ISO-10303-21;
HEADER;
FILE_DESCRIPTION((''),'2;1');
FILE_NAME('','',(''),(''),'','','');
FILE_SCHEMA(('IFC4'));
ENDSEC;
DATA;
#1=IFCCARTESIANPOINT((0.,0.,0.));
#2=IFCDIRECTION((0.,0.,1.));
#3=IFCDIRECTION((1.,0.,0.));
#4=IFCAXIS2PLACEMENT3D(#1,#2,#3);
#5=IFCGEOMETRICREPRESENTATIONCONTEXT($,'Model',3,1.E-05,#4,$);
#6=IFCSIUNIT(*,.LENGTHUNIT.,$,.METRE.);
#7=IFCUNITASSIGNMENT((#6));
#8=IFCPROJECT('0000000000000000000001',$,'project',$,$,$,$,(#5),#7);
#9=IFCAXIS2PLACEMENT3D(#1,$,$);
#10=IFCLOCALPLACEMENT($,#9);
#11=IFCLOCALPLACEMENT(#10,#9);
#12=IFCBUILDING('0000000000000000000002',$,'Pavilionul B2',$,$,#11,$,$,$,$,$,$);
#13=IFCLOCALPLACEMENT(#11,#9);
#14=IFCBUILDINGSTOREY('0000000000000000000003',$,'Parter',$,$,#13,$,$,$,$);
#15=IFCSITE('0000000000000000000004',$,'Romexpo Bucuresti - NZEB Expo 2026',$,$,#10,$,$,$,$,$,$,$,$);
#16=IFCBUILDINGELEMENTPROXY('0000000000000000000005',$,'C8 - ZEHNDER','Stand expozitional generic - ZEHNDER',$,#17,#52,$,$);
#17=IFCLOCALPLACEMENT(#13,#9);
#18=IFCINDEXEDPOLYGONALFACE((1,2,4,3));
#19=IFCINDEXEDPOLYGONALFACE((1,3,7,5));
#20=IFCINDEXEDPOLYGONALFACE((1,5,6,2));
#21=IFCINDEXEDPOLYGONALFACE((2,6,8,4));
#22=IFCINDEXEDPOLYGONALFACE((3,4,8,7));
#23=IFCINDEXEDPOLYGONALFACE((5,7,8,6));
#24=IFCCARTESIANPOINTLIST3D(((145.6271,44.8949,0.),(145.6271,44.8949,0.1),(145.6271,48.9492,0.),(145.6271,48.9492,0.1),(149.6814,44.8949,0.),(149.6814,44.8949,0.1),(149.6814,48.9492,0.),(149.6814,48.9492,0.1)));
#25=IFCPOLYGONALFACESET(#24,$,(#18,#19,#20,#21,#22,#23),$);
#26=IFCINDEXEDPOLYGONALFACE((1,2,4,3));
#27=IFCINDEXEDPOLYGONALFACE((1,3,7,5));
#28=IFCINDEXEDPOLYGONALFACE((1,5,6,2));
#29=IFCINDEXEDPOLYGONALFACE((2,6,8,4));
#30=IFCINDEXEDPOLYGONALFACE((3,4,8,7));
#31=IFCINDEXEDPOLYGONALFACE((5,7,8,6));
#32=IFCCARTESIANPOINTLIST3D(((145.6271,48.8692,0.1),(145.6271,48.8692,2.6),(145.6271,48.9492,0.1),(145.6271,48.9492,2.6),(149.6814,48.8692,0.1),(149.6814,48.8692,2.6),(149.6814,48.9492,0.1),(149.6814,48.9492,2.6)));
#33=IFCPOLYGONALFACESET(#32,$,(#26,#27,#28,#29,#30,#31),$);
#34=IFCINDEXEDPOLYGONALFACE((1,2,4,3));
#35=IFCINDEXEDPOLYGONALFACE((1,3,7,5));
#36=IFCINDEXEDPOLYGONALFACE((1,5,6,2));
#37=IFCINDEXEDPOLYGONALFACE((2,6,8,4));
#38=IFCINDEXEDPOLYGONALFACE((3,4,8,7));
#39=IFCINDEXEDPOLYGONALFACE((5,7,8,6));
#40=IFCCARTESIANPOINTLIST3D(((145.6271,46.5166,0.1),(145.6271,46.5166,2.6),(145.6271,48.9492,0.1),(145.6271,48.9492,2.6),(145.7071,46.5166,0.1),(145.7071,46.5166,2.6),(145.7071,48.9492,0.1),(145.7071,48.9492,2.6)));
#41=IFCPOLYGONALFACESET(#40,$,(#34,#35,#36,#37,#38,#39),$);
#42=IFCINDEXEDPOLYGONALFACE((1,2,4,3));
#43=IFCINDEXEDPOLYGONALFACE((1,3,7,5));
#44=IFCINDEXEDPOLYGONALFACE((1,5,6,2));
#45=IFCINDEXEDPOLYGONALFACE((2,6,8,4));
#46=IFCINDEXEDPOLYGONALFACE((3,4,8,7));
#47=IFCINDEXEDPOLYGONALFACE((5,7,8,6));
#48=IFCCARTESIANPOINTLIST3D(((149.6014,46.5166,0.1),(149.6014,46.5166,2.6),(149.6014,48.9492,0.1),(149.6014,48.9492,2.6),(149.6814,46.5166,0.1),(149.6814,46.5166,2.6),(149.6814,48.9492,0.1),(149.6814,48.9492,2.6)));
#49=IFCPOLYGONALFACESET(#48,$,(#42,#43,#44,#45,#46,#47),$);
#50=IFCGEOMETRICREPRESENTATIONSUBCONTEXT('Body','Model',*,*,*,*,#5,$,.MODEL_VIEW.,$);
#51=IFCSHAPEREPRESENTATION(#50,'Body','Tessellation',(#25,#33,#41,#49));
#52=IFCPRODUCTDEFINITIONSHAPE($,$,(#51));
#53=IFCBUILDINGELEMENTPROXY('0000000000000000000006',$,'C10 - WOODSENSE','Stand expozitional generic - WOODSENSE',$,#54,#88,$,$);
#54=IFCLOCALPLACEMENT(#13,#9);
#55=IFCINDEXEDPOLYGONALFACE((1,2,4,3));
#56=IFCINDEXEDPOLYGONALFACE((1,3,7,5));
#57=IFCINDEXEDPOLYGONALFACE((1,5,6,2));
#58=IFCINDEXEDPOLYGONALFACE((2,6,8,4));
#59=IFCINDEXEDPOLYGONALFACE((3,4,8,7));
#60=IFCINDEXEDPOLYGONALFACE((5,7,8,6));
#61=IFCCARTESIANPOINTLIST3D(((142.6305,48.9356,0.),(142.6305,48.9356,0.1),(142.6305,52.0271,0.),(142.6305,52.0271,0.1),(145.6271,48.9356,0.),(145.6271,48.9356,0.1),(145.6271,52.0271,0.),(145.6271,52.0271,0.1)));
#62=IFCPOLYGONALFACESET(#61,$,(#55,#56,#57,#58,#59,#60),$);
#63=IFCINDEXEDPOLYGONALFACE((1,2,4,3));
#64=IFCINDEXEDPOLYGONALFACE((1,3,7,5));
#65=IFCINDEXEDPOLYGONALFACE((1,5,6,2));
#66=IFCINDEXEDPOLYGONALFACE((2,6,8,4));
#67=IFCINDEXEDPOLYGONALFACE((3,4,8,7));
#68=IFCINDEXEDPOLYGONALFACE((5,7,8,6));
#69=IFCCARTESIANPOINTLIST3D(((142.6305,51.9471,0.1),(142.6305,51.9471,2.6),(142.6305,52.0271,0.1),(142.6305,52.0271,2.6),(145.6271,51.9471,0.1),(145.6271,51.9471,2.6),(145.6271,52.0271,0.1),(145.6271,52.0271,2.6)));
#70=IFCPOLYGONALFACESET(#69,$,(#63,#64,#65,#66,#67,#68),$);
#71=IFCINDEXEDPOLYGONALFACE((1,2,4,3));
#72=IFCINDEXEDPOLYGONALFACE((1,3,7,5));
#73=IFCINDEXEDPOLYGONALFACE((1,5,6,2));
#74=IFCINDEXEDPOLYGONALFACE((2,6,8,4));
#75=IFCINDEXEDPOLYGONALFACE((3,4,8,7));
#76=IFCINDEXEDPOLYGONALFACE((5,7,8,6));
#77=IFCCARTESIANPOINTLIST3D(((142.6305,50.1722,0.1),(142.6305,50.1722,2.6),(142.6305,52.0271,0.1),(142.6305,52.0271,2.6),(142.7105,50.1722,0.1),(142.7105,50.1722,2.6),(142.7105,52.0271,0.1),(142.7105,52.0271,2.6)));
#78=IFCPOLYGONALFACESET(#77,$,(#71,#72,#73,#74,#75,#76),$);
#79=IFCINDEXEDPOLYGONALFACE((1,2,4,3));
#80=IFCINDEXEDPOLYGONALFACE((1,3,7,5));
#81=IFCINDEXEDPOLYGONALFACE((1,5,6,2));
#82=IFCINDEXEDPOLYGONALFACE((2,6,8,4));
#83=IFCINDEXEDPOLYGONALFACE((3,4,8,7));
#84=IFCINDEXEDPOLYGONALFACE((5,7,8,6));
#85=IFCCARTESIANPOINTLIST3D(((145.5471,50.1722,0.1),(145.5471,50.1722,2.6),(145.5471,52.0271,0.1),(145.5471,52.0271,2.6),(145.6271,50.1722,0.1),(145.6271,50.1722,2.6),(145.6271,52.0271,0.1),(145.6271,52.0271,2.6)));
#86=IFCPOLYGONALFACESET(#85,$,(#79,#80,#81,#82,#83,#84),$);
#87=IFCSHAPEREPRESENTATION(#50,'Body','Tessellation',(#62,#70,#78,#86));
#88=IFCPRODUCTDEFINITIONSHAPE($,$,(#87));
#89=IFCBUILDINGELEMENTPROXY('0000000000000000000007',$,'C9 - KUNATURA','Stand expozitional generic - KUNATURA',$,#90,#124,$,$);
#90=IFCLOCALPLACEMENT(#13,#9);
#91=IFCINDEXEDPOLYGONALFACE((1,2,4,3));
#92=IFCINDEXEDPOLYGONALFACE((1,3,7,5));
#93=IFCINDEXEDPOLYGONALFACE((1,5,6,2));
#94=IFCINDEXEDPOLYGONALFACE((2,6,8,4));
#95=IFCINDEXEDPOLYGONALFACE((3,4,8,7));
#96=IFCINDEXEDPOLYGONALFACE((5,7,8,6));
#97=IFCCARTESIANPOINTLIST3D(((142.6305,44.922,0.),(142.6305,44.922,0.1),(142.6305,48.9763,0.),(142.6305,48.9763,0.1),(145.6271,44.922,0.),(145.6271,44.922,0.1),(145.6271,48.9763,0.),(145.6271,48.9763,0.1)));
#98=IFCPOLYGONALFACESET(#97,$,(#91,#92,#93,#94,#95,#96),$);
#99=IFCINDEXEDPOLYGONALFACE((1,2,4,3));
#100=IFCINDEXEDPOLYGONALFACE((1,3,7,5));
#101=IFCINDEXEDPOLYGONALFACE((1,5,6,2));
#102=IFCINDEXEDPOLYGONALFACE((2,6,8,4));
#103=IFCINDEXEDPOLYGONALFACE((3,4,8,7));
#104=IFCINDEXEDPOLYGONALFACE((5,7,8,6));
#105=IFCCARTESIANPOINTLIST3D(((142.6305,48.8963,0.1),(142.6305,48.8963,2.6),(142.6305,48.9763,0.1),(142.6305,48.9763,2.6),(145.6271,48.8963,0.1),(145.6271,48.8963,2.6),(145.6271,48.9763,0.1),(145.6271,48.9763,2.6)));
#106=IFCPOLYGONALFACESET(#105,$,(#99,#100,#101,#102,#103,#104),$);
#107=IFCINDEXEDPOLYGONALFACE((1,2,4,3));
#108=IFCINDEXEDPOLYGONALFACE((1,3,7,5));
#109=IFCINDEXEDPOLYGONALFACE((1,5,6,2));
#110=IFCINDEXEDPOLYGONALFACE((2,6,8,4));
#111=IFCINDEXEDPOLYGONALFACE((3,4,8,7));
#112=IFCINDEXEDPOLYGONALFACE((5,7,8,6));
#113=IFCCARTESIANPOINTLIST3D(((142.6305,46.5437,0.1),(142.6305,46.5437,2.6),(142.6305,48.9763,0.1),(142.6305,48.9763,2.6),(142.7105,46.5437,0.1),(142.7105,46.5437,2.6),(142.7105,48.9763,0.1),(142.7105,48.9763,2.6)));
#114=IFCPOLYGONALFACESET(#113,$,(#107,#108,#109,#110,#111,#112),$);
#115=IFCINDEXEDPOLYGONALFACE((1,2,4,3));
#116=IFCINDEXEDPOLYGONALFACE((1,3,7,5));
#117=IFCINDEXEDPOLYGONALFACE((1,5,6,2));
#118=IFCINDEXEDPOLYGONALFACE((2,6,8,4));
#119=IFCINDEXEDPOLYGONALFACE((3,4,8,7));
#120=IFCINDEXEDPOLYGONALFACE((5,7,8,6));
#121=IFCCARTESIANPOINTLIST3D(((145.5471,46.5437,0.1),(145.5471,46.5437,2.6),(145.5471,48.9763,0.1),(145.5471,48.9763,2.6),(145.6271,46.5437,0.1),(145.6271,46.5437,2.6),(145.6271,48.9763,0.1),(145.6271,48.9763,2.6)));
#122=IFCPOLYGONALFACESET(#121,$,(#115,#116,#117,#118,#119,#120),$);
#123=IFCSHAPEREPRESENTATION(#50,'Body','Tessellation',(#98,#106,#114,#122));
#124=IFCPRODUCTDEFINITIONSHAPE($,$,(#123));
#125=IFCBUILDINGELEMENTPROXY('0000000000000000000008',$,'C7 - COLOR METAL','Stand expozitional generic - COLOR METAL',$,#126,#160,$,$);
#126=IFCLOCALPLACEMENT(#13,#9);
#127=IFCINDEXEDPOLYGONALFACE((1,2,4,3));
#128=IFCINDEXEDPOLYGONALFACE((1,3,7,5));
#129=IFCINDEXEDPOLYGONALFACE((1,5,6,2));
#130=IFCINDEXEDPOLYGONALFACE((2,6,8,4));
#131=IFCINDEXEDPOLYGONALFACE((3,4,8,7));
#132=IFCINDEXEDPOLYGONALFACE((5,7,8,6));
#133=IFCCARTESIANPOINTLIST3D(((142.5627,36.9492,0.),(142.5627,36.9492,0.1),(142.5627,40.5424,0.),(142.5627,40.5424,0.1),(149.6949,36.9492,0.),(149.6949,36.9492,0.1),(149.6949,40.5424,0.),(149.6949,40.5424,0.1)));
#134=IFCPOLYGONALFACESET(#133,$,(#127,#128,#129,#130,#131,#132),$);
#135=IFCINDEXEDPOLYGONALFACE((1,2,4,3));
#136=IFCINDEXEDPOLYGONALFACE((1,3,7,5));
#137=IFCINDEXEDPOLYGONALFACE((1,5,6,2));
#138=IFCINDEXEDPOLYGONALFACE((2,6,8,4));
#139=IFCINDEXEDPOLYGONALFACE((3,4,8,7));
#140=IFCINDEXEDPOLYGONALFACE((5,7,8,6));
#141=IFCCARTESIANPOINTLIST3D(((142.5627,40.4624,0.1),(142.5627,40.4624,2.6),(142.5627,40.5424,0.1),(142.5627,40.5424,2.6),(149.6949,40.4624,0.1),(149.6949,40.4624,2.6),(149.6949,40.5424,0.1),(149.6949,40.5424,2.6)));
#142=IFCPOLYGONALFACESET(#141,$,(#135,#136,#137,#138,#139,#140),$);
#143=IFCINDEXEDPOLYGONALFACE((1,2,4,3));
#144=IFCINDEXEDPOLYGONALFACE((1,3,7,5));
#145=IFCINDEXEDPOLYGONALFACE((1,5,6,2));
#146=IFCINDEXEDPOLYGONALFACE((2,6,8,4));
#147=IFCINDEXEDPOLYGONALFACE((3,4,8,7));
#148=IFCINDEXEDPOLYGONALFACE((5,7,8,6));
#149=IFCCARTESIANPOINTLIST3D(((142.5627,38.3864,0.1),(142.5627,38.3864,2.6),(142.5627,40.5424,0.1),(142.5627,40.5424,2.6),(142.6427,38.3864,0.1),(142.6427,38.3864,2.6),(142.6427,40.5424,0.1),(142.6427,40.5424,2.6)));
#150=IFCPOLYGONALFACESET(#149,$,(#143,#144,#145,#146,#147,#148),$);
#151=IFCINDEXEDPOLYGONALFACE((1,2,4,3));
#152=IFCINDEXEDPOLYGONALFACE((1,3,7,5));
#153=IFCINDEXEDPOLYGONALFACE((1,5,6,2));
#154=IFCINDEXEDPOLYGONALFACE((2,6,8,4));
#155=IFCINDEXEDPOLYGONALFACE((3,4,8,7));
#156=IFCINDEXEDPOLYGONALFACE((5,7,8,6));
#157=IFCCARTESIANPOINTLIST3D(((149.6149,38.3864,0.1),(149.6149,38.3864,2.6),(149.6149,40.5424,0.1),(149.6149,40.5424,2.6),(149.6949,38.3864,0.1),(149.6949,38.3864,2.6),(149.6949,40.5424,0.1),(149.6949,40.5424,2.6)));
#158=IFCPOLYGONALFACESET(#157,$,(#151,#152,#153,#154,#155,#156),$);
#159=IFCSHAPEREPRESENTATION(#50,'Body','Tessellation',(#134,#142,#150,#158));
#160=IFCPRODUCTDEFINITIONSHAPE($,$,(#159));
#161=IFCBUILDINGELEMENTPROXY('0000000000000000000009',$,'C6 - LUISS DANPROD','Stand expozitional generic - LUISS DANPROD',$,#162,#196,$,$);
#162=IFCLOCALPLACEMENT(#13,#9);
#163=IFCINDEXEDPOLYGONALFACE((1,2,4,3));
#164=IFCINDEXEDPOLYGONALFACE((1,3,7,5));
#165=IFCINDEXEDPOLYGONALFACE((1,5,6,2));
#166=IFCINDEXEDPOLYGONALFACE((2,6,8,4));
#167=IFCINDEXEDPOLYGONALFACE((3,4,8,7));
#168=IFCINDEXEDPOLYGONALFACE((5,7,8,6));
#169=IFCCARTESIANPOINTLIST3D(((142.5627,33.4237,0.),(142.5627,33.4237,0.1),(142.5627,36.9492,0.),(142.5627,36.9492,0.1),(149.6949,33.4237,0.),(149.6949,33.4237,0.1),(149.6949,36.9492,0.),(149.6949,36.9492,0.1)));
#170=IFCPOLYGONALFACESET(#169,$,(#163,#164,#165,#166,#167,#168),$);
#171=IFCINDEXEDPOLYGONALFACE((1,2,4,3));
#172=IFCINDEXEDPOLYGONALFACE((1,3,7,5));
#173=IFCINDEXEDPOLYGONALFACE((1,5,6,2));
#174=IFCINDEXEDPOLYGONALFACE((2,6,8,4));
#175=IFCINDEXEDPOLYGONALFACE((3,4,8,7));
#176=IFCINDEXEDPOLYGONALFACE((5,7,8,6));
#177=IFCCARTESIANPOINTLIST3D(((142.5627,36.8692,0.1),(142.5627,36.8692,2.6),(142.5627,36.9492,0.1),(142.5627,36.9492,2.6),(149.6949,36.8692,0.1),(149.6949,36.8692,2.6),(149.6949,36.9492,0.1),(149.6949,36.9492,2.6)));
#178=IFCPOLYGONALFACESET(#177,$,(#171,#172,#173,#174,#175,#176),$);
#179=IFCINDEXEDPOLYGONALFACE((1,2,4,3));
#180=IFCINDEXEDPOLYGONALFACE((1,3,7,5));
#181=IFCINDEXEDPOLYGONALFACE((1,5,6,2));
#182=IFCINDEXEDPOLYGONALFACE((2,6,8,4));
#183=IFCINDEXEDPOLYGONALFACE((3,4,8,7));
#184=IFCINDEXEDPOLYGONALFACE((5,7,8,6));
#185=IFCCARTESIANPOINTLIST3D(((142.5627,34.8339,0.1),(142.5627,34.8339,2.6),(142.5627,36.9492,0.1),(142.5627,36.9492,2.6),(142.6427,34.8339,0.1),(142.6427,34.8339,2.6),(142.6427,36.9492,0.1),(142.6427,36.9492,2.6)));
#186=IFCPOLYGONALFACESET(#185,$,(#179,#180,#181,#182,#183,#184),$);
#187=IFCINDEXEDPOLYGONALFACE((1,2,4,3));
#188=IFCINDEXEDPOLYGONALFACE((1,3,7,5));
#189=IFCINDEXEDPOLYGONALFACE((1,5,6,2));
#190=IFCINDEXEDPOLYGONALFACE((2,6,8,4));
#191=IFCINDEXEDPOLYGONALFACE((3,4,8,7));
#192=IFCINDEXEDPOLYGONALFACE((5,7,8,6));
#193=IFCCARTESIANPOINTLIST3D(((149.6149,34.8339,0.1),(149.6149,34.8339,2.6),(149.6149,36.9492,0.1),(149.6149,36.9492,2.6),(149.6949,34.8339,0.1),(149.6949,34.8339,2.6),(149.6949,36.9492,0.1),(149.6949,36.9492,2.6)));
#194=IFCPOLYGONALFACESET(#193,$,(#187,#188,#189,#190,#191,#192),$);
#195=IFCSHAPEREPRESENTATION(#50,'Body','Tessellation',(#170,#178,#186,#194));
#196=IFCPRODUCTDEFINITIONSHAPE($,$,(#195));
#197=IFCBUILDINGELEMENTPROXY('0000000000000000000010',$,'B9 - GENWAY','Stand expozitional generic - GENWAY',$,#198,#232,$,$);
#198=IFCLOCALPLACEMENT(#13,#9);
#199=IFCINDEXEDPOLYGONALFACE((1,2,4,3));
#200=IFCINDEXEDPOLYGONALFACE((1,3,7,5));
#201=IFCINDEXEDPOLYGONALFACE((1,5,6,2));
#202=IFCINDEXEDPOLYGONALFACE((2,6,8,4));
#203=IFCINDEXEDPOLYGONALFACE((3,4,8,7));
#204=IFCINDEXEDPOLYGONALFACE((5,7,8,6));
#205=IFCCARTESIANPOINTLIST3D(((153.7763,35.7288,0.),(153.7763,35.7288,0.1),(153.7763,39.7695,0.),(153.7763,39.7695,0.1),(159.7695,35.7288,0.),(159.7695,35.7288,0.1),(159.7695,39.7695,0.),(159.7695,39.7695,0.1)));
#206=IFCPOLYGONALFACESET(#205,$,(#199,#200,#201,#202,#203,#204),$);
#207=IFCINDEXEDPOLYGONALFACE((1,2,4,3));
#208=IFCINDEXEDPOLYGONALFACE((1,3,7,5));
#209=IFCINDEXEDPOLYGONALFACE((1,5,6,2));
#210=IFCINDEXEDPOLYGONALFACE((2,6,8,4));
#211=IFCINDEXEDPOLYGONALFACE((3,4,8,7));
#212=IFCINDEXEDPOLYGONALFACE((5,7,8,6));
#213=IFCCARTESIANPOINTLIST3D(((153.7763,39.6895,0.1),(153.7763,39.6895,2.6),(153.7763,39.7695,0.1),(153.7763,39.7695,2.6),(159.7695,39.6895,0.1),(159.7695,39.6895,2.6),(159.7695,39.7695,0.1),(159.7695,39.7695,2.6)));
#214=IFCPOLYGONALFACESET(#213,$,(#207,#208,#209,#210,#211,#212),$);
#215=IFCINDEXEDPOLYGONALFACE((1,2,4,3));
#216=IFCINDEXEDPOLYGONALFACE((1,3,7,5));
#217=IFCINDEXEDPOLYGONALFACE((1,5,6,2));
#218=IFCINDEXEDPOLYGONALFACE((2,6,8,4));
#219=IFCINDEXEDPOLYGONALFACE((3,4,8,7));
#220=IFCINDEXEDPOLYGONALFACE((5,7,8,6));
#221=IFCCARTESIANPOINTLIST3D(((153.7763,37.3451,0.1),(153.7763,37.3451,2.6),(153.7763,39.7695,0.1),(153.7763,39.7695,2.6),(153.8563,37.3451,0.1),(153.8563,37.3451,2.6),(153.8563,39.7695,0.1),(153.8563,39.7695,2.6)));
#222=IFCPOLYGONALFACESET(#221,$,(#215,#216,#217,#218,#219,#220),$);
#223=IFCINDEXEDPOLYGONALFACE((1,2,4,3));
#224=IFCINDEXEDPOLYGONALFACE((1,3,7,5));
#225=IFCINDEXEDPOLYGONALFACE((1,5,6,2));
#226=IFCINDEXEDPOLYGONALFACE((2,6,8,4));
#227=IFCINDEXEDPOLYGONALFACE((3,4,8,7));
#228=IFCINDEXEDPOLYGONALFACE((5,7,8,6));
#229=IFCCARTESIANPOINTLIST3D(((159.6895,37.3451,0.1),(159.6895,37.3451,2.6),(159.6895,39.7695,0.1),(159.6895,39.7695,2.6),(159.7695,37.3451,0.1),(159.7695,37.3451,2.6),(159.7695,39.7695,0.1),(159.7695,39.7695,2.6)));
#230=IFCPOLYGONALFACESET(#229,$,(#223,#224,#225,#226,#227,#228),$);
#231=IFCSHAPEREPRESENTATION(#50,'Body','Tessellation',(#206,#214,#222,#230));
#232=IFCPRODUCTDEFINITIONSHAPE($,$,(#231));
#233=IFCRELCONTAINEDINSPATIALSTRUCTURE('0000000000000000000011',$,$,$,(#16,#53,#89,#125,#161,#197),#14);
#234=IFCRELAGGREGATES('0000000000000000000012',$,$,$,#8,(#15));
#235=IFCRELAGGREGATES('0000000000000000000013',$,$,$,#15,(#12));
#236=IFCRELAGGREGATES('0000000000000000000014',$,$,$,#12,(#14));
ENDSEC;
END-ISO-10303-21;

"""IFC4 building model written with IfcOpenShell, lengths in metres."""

from ifc_helpers import new_model, si_unit, frame, frame_2d, origin, origin_with_axes, place, context, subcontext, project, spatial, rectangle, extrude, element, save


model = new_model("IFC4")

# Units and contexts
model_context = context("Model", 3, precision=1e-05, world=origin_with_axes())
body_context = subcontext(model_context, "Body", "Model", "MODEL_VIEW")
ifc_project = project(units=[si_unit("LENGTHUNIT", "METRE")], contexts=[model_context])

# Site, building, storey
site_placement = place(None, origin())
site = spatial("IfcSite", under=ifc_project, at=site_placement, Name="Romexpo Bucuresti - NZEB Expo 2026")
building_placement = place(site_placement, origin())
building = spatial("IfcBuilding", under=site, at=building_placement, Name="Pavilionul B2")
storey_placement = place(building_placement, origin())
storey = spatial("IfcBuildingStorey", under=building, at=storey_placement, Name="Parter")

# Building element proxies
proxy_1_placement = place(storey_placement, frame((145.6271, 44.8949, 0.0), z_axis=(0.0, 0.0, 1.0), x_axis=(1.0, 0.0, 0.0)))
element("IfcBuildingElementProxy", 1, at=proxy_1_placement, inside=storey, Name="C8 - ZEHNDER", Description="Stand expozitional generic - ZEHNDER", context=body_context, shape_type="SweptSolid", body=[
    extrude(rectangle(XDim=4.0542, YDim=4.0542, at=frame_2d((2.0271, 2.0271))), origin(), (0.0, 0.0, 1.0), 0.1),
    extrude(rectangle(XDim=4.0542, YDim=0.08, at=frame_2d((2.0271, 4.0142))), frame((0.0, 0.0, 0.1)), (0.0, 0.0, 1.0), 2.5),
    extrude(rectangle(XDim=0.08, YDim=2.4325, at=frame_2d((0.04, 2.838))), frame((0.0, 0.0, 0.1)), (0.0, 0.0, 1.0), 2.5),
    extrude(rectangle(XDim=0.08, YDim=2.4325, at=frame_2d((4.0142, 2.838))), frame((0.0, 0.0, 0.1)), (0.0, 0.0, 1.0), 2.5),
])
proxy_2_placement = place(storey_placement, frame((142.6305, 48.9356, 0.0), z_axis=(0.0, 0.0, 1.0), x_axis=(1.0, 0.0, 0.0)))
element("IfcBuildingElementProxy", 2, at=proxy_2_placement, inside=storey, Name="C10 - WOODSENSE", Description="Stand expozitional generic - WOODSENSE", context=body_context, shape_type="SweptSolid", body=[
    extrude(rectangle(XDim=2.9966, YDim=3.0915, at=frame_2d((1.4983, 1.5458))), origin(), (0.0, 0.0, 1.0), 0.1),
    extrude(rectangle(XDim=2.9966, YDim=0.08, at=frame_2d((1.4983, 3.0515))), frame((0.0, 0.0, 0.1)), (0.0, 0.0, 1.0), 2.5),
    extrude(rectangle(XDim=0.08, YDim=1.8549, at=frame_2d((0.04, 2.1641))), frame((0.0, 0.0, 0.1)), (0.0, 0.0, 1.0), 2.5),
    extrude(rectangle(XDim=0.08, YDim=1.8549, at=frame_2d((2.9566, 2.1641))), frame((0.0, 0.0, 0.1)), (0.0, 0.0, 1.0), 2.5),
])
proxy_3_placement = place(storey_placement, frame((142.6305, 44.922, 0.0), z_axis=(0.0, 0.0, 1.0), x_axis=(1.0, 0.0, 0.0)))
element("IfcBuildingElementProxy", 3, at=proxy_3_placement, inside=storey, Name="C9 - KUNATURA", Description="Stand expozitional generic - KUNATURA", context=body_context, shape_type="SweptSolid", body=[
    extrude(rectangle(XDim=2.9966, YDim=4.0542, at=frame_2d((1.4983, 2.0271))), origin(), (0.0, 0.0, 1.0), 0.1),
    extrude(rectangle(XDim=2.9966, YDim=0.08, at=frame_2d((1.4983, 4.0142))), frame((0.0, 0.0, 0.1)), (0.0, 0.0, 1.0), 2.5),
    extrude(rectangle(XDim=0.08, YDim=2.4325, at=frame_2d((0.04, 2.838))), frame((0.0, 0.0, 0.1)), (0.0, 0.0, 1.0), 2.5),
    extrude(rectangle(XDim=0.08, YDim=2.4325, at=frame_2d((2.9566, 2.838))), frame((0.0, 0.0, 0.1)), (0.0, 0.0, 1.0), 2.5),
])
proxy_4_placement = place(storey_placement, frame((142.5627, 36.9492, 0.0), z_axis=(0.0, 0.0, 1.0), x_axis=(1.0, 0.0, 0.0)))
element("IfcBuildingElementProxy", 4, at=proxy_4_placement, inside=storey, Name="C7 - COLOR METAL", Description="Stand expozitional generic - COLOR METAL", context=body_context, shape_type="SweptSolid", body=[
    extrude(rectangle(XDim=7.1322, YDim=3.5932, at=frame_2d((3.5661, 1.7966))), origin(), (0.0, 0.0, 1.0), 0.1),
    extrude(rectangle(XDim=7.1322, YDim=0.08, at=frame_2d((3.5661, 3.5532))), frame((0.0, 0.0, 0.1)), (0.0, 0.0, 1.0), 2.5),
    extrude(rectangle(XDim=0.08, YDim=2.1559, at=frame_2d((0.04, 2.5153))), frame((0.0, 0.0, 0.1)), (0.0, 0.0, 1.0), 2.5),
    extrude(rectangle(XDim=0.08, YDim=2.1559, at=frame_2d((7.0922, 2.5153))), frame((0.0, 0.0, 0.1)), (0.0, 0.0, 1.0), 2.5),
])
proxy_5_placement = place(storey_placement, frame((142.5627, 33.4237, 0.0), z_axis=(0.0, 0.0, 1.0), x_axis=(1.0, 0.0, 0.0)))
element("IfcBuildingElementProxy", 5, at=proxy_5_placement, inside=storey, Name="C6 - LUISS DANPROD", Description="Stand expozitional generic - LUISS DANPROD", context=body_context, shape_type="SweptSolid", body=[
    extrude(rectangle(XDim=7.1322, YDim=3.5254, at=frame_2d((3.5661, 1.7627))), origin(), (0.0, 0.0, 1.0), 0.1),
    extrude(rectangle(XDim=7.1322, YDim=0.08, at=frame_2d((3.5661, 3.4854))), frame((0.0, 0.0, 0.1)), (0.0, 0.0, 1.0), 2.5),
    extrude(rectangle(XDim=0.08, YDim=2.1153, at=frame_2d((0.04, 2.4678))), frame((0.0, 0.0, 0.1)), (0.0, 0.0, 1.0), 2.5),
    extrude(rectangle(XDim=0.08, YDim=2.1153, at=frame_2d((7.0922, 2.4678))), frame((0.0, 0.0, 0.1)), (0.0, 0.0, 1.0), 2.5),
])
proxy_6_placement = place(storey_placement, frame((153.7763, 35.7288, 0.0), z_axis=(0.0, 0.0, 1.0), x_axis=(1.0, 0.0, 0.0)))
element("IfcBuildingElementProxy", 6, at=proxy_6_placement, inside=storey, Name="B9 - GENWAY", Description="Stand expozitional generic - GENWAY", context=body_context, shape_type="SweptSolid", body=[
    extrude(rectangle(XDim=5.9932, YDim=4.0407, at=frame_2d((2.9966, 2.0203))), origin(), (0.0, 0.0, 1.0), 0.1),
    extrude(rectangle(XDim=5.9932, YDim=0.08, at=frame_2d((2.9966, 4.0007))), frame((0.0, 0.0, 0.1)), (0.0, 0.0, 1.0), 2.5),
    extrude(rectangle(XDim=0.08, YDim=2.4244, at=frame_2d((0.04, 2.8285))), frame((0.0, 0.0, 0.1)), (0.0, 0.0, 1.0), 2.5),
    extrude(rectangle(XDim=0.08, YDim=2.4244, at=frame_2d((5.9532, 2.8285))), frame((0.0, 0.0, 0.1)), (0.0, 0.0, 1.0), 2.5),
])

save(model, "model.ifc")
